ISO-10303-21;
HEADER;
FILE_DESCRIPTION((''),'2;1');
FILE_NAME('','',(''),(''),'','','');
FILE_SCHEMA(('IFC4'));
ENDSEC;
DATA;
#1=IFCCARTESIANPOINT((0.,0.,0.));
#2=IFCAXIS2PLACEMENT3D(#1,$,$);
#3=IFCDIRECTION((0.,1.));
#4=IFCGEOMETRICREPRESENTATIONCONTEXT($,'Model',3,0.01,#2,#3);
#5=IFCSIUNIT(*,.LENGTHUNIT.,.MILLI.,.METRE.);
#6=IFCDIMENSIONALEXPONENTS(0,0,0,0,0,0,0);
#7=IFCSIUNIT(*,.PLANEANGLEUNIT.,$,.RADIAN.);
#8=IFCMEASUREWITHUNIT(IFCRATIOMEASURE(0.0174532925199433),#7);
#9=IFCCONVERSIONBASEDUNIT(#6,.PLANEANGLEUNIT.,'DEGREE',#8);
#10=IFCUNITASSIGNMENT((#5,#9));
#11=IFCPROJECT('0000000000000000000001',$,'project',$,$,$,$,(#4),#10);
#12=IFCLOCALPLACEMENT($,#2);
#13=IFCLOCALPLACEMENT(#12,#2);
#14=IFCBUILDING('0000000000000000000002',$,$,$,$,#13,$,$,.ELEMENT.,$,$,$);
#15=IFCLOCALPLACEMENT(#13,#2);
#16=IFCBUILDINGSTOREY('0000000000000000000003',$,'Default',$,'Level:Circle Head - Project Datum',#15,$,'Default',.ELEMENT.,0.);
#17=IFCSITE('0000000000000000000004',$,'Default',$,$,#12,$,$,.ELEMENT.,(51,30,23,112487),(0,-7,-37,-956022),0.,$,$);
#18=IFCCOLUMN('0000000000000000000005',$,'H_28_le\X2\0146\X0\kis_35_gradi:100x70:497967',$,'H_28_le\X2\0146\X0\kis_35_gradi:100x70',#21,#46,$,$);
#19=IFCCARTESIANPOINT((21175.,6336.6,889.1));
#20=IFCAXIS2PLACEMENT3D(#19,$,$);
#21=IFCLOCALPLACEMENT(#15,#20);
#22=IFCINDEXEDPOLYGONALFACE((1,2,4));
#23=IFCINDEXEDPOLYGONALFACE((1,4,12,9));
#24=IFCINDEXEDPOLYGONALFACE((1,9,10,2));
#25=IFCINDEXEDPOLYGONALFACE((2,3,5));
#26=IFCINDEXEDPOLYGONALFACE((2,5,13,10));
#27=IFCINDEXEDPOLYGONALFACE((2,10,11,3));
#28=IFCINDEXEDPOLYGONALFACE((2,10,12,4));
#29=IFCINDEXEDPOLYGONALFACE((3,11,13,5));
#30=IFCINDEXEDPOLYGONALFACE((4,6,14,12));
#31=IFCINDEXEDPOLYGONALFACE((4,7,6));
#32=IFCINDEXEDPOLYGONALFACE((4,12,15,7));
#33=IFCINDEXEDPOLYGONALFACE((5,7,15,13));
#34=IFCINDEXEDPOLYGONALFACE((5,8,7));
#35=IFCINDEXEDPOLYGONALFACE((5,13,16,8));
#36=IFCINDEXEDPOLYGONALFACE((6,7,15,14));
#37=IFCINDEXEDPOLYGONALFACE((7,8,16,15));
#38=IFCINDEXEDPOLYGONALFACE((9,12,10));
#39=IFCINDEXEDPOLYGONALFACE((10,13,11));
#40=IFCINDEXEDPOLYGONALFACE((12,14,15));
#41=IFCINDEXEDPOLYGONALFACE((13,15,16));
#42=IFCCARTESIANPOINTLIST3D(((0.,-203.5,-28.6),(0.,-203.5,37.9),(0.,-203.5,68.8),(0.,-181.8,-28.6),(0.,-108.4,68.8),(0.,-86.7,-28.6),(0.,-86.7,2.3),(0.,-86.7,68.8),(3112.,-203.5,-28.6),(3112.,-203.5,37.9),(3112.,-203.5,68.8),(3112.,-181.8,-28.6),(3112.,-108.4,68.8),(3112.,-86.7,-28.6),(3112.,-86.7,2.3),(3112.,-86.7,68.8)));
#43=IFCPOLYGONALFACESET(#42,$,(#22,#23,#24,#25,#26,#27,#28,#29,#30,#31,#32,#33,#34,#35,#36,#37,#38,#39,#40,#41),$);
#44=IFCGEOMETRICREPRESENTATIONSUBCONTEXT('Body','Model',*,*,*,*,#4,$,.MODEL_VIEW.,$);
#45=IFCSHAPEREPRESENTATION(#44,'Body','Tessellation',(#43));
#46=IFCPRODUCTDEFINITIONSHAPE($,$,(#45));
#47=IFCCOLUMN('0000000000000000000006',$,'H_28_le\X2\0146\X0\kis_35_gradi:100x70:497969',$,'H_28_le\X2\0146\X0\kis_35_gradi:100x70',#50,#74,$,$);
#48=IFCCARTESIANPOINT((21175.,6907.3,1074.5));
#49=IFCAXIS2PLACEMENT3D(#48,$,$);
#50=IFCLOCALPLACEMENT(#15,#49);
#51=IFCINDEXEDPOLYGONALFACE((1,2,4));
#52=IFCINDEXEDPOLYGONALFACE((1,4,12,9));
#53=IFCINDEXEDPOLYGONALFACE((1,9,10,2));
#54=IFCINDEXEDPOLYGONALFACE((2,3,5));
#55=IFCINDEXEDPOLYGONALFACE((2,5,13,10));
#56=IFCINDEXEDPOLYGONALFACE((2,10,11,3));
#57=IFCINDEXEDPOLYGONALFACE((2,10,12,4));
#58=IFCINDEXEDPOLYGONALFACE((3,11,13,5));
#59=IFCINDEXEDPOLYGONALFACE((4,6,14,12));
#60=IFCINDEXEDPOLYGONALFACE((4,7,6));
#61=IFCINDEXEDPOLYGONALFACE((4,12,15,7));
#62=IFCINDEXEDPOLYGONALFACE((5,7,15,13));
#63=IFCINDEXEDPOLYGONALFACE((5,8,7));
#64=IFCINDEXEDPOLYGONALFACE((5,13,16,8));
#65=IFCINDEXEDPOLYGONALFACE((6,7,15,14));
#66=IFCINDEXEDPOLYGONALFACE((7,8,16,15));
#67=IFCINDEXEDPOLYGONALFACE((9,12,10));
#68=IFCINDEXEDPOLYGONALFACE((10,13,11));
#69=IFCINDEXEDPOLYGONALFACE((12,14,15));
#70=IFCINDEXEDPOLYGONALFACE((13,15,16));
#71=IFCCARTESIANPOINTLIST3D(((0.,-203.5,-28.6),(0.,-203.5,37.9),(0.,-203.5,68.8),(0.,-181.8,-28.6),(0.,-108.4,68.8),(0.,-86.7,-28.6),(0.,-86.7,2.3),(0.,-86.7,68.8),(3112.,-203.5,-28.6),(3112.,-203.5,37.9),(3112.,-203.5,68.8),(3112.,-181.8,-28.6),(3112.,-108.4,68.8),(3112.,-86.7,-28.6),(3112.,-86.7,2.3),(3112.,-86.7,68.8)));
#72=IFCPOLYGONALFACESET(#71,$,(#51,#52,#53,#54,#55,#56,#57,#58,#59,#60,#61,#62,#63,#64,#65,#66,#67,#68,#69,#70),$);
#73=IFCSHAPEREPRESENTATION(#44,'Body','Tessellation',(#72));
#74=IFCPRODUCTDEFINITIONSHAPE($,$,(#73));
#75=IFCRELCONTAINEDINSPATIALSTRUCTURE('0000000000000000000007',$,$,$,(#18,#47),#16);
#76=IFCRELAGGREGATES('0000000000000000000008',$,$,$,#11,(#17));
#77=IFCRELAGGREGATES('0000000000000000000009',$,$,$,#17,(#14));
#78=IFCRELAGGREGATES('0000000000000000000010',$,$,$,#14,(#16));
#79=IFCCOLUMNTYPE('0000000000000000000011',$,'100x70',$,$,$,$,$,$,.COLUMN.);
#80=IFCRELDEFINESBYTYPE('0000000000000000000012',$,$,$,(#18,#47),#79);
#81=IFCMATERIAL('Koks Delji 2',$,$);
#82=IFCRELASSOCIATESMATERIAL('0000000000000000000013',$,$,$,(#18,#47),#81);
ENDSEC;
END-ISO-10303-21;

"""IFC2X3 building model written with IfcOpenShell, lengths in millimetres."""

from ifc_helpers import new_model, entity, si_unit, converted_unit, direction, frame, frame_2d, origin, origin_2d_with_axis, place, context, subcontext, project, spatial, rectangle, extrude, boolean, source, transform, mapped, material, type_object, type_shapes, element, save


model = new_model("IFC2X3")

# Units and contexts
model_context = context("Model", 3, precision=0.01, world=origin(), true_north=direction((0.0, 1.0)))
body_context = subcontext(model_context, "Body", "Model", "MODEL_VIEW")
ifc_project = project(units=[si_unit("LENGTHUNIT", "METRE", prefix="MILLI"), converted_unit("PLANEANGLEUNIT", "DEGREE", entity("IfcRatioMeasure", 0.0174532925199433), si_unit("PLANEANGLEUNIT", "RADIAN"), dimensions=[0, 0, 0, 0, 0, 0, 0])], contexts=[model_context])

# Site, building, storey
site_placement = place(None, origin())
site = spatial("IfcSite", under=ifc_project, at=site_placement, Name="Default", CompositionType="ELEMENT", RefLatitude=(51, 30, 23, 112487), RefLongitude=(0, -7, -37, -956022), RefElevation=0.0)
building_placement = place(site_placement, origin())
building = spatial("IfcBuilding", under=site, at=building_placement, CompositionType="ELEMENT")
storey_placement = place(building_placement, origin())
storey = spatial("IfcBuildingStorey", under=building, at=storey_placement, Name="Default", ObjectType="Level:Circle Head - Project Datum", LongName="Default", CompositionType="ELEMENT", Elevation=0.0)

# Columns
ifc_material_1 = material(Name="Koks Delji 2")
column_type = type_object("IfcColumnType", Name="100x70", PredefinedType="COLUMN")
shared_shape_1 = source(origin(), body_context, "Body", "CSG", [
    boolean("DIFFERENCE", extrude(rectangle(XDim=3112.0, YDim=116.7, at=origin_2d_with_axis()), frame((1556.0, -145.1, -28.6)), (0.0, 0.0, 1.0), 97.5), extrude(rectangle(XDim=70.0, YDim=100.0, at=frame_2d((0.0, 0.0), x_axis=(0.0, 1.0))), frame((0.0, -145.1, 20.1), z_axis=(-1.0, 0.0, 0.0), x_axis=(0.0, -0.951057, -0.309017)), (0.0, 0.0, -1.0), 3112.0)),
])
type_shapes(column_type, [shared_shape_1])
for number, where, name in (
    (1, (21175.0, 6336.6, 889.1), "H_28_leņkis_35_gradi:100x70:497967"),
    (2, (21175.0, 6907.3, 1074.5), "H_28_leņkis_35_gradi:100x70:497969"),
):
    element("IfcColumn", number, at=place(storey_placement, frame(where)), inside=storey, type_object=column_type, material=ifc_material_1, Name=name, ObjectType="H_28_leņkis_35_gradi:100x70", context=body_context, shape_type="MappedRepresentation", body=[
        mapped(shared_shape_1, transform((0.0, 0.0, 0.0), scale=1.0)),
    ])

save(model, "model.ifc")
